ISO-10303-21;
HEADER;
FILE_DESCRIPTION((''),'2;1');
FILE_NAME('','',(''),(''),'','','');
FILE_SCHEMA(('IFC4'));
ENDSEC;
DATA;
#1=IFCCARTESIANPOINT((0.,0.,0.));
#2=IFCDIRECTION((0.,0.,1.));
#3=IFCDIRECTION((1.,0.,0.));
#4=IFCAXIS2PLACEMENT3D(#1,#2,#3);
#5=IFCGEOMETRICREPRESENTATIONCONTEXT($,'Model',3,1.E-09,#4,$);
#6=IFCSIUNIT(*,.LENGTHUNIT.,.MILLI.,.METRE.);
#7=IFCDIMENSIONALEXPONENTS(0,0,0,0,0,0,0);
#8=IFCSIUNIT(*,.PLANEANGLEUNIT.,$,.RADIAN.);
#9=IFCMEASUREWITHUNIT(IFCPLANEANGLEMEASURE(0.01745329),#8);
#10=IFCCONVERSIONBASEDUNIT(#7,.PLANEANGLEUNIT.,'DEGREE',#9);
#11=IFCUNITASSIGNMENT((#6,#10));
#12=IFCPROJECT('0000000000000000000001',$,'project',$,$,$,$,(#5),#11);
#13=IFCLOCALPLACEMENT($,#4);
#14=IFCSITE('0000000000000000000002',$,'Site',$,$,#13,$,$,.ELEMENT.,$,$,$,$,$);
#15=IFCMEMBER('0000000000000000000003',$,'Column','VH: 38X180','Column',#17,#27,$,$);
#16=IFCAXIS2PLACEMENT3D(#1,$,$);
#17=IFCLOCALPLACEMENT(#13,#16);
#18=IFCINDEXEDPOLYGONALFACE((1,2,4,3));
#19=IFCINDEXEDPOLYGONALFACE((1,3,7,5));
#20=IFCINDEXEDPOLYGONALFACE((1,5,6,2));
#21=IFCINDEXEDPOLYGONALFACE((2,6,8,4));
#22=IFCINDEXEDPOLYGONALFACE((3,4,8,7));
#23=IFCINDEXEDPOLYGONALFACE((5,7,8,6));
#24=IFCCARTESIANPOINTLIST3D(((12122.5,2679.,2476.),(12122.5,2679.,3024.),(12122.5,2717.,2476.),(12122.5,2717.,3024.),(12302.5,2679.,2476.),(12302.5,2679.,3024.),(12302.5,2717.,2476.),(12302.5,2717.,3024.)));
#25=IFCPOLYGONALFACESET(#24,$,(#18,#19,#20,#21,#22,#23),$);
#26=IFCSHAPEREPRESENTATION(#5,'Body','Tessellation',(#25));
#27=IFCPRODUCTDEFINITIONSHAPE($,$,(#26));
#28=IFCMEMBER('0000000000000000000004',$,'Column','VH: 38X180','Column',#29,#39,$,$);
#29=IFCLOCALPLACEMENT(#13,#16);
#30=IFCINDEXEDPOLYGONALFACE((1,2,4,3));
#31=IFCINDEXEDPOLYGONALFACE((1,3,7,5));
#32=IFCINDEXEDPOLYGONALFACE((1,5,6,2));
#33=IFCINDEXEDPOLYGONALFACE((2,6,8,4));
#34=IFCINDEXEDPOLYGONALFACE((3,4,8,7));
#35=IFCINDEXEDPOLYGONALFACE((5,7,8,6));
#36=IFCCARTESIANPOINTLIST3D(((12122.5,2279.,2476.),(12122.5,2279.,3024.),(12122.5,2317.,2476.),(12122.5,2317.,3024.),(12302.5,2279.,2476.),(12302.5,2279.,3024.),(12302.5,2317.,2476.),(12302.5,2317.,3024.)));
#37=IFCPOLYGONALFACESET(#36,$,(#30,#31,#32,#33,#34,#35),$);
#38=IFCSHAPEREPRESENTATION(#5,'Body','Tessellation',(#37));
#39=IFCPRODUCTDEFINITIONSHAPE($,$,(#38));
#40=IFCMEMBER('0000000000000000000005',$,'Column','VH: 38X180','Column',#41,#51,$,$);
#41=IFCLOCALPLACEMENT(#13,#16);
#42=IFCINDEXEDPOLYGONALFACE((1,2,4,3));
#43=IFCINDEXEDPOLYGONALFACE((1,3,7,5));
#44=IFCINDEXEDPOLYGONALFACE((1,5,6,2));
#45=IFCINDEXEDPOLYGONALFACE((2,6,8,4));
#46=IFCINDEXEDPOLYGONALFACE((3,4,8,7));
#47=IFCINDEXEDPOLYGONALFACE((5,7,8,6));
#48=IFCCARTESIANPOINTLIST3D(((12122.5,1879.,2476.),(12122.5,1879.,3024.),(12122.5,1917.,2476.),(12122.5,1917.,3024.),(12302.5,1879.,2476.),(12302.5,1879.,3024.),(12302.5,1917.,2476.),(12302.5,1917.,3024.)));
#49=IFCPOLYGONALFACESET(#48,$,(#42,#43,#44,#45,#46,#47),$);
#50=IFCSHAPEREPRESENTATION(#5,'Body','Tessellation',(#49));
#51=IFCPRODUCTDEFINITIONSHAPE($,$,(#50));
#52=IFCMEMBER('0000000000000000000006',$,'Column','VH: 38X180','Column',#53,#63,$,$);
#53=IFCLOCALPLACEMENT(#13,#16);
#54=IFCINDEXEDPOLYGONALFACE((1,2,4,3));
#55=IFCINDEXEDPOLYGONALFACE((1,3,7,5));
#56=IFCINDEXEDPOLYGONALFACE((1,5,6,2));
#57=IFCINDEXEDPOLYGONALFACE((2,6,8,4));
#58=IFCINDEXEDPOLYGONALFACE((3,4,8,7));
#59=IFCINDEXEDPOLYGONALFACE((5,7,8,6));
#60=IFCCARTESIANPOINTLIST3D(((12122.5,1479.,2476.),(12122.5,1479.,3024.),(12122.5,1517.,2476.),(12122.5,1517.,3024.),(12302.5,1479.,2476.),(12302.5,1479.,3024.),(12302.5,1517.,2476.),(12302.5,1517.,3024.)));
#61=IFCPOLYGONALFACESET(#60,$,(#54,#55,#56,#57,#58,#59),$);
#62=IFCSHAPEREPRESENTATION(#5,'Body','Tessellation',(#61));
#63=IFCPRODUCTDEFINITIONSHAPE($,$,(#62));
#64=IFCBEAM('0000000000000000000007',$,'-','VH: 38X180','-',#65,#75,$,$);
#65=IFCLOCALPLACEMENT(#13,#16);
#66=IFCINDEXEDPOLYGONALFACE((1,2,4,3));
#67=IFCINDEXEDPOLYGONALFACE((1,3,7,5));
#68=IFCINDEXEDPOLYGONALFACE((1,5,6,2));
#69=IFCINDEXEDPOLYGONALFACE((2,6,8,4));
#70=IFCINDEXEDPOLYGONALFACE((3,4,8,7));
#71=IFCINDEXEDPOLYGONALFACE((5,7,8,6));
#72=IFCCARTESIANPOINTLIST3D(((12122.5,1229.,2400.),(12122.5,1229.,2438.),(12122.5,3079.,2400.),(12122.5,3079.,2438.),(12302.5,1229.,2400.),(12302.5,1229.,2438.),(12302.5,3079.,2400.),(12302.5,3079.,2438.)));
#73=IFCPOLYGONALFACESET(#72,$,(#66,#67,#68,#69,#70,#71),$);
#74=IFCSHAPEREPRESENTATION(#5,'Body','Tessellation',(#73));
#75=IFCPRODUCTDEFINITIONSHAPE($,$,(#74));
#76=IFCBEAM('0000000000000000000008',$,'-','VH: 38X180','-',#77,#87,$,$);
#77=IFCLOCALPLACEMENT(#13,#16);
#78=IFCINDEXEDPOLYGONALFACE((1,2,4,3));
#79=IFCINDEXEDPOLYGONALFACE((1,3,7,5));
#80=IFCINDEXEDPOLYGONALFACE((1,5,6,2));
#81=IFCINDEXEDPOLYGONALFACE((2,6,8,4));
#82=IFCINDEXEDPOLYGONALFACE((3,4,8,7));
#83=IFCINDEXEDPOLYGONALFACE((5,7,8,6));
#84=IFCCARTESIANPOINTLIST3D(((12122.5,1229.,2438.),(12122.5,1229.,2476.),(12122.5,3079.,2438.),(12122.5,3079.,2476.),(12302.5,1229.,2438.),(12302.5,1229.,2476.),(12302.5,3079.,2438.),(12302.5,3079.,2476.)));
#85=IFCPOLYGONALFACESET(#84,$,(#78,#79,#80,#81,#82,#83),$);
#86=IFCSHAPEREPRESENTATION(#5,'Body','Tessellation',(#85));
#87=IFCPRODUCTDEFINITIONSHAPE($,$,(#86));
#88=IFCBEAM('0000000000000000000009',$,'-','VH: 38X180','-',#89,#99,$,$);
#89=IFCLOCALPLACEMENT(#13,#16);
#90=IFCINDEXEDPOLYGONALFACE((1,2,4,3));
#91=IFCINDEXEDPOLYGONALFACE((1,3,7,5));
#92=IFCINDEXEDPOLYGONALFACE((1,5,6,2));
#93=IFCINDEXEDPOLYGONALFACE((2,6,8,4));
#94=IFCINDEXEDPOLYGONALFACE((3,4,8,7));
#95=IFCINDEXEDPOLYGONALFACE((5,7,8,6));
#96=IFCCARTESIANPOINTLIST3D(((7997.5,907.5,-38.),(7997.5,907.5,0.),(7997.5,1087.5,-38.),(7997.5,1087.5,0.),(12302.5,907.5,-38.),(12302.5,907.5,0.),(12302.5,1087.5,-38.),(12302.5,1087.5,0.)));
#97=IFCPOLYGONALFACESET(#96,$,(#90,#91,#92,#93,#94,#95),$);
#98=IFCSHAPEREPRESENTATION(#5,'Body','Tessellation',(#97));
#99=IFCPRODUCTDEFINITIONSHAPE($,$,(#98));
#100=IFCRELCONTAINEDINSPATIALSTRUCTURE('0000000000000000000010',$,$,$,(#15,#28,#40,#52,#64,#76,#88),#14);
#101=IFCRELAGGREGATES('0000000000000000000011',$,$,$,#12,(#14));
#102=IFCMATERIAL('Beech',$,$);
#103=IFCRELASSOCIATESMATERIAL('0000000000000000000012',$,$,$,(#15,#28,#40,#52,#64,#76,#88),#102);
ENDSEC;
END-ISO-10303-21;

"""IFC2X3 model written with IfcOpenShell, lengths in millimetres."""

from ifc_helpers import new_model, entity, si_unit, converted_unit, frame, origin, origin_with_axes, origin_2d, place, context, project, spatial, rectangle, extrude, material, element, save


model = new_model("IFC2X3")

# Units and contexts
model_context = context("Model", 3, precision=1e-09, world=origin_with_axes())
ifc_project = project(units=[si_unit("LENGTHUNIT", "METRE", prefix="MILLI"), converted_unit("PLANEANGLEUNIT", "DEGREE", entity("IfcPlaneAngleMeasure", 0.01745329), si_unit("PLANEANGLEUNIT", "RADIAN"), dimensions=[0, 0, 0, 0, 0, 0, 0])], contexts=[model_context])

# Site
site_placement = place(None, origin_with_axes())
site = spatial("IfcSite", under=ifc_project, at=site_placement, Name="Site", CompositionType="ELEMENT")

# Shared definitions
ifc_material_1 = material(Name="Beech")

# Members
for number, where, z_axis, x_axis, name in (
    (1, (12212.5, 2698.0, 2476.0), (-0.000057, 0.0, -1.0), (0.0, -1.0, 0.0), "Column"),
    (2, (12212.5, 2298.0, 2476.0), (-0.000057, 0.0, -1.0), (0.0, -1.0, 0.0), "Column"),
    (3, (12212.5, 1898.0, 2476.0), (-0.000057, 0.0, -1.0), (0.0, -1.0, 0.0), "Column"),
    (4, (12212.5, 1498.0, 2476.0), (-0.000057, 0.0, -1.0), (0.0, -1.0, 0.0), "Column"),
):
    element("IfcMember", number, at=place(None, frame(where, z_axis=z_axis, x_axis=x_axis)), inside=site, material=ifc_material_1, Name=name, Description="VH: 38X180", ObjectType="Column", context=model_context, shape_type="SweptSolid", body=[
        extrude(rectangle(XDim=38.0, YDim=180.0, at=origin_2d()), origin(), (0.0, 0.0, -1.0), 548.0),
    ])

# Beams
for number, where, z_axis, x_axis, name in (
    (5, (12212.5, 3079.0, 2419.0), (0.0, -1.0, 0.0), (0.0, 0.0, 1.0), "-"),
    (6, (12212.5, 3079.0, 2457.0), (0.0, -1.0, 0.0), (0.0, 0.0, 1.0), "-"),
):
    element("IfcBeam", number, at=place(None, frame(where, z_axis=z_axis, x_axis=x_axis)), inside=site, material=ifc_material_1, Name=name, Description="VH: 38X180", ObjectType="-", context=model_context, shape_type="SweptSolid", body=[
        extrude(rectangle(XDim=38.0, YDim=180.0, at=origin_2d()), origin(), (0.0, 0.0, 1.0), 1850.1),
    ])
beam_1_placement = place(None, frame((12302.5, 997.5, -19.0), z_axis=(1.0, -0.000003, 0.0), x_axis=(0.0, 0.0, -1.0)))
element("IfcBeam", 7, at=beam_1_placement, inside=site, material=ifc_material_1, Name="-", Description="VH: 38X180", ObjectType="-", context=model_context, shape_type="SweptSolid", body=[
    extrude(rectangle(XDim=38.0, YDim=180.0, at=origin_2d()), origin(), (0.0, 0.0, -1.0), 4305.0),
])

save(model, "model.ifc")
